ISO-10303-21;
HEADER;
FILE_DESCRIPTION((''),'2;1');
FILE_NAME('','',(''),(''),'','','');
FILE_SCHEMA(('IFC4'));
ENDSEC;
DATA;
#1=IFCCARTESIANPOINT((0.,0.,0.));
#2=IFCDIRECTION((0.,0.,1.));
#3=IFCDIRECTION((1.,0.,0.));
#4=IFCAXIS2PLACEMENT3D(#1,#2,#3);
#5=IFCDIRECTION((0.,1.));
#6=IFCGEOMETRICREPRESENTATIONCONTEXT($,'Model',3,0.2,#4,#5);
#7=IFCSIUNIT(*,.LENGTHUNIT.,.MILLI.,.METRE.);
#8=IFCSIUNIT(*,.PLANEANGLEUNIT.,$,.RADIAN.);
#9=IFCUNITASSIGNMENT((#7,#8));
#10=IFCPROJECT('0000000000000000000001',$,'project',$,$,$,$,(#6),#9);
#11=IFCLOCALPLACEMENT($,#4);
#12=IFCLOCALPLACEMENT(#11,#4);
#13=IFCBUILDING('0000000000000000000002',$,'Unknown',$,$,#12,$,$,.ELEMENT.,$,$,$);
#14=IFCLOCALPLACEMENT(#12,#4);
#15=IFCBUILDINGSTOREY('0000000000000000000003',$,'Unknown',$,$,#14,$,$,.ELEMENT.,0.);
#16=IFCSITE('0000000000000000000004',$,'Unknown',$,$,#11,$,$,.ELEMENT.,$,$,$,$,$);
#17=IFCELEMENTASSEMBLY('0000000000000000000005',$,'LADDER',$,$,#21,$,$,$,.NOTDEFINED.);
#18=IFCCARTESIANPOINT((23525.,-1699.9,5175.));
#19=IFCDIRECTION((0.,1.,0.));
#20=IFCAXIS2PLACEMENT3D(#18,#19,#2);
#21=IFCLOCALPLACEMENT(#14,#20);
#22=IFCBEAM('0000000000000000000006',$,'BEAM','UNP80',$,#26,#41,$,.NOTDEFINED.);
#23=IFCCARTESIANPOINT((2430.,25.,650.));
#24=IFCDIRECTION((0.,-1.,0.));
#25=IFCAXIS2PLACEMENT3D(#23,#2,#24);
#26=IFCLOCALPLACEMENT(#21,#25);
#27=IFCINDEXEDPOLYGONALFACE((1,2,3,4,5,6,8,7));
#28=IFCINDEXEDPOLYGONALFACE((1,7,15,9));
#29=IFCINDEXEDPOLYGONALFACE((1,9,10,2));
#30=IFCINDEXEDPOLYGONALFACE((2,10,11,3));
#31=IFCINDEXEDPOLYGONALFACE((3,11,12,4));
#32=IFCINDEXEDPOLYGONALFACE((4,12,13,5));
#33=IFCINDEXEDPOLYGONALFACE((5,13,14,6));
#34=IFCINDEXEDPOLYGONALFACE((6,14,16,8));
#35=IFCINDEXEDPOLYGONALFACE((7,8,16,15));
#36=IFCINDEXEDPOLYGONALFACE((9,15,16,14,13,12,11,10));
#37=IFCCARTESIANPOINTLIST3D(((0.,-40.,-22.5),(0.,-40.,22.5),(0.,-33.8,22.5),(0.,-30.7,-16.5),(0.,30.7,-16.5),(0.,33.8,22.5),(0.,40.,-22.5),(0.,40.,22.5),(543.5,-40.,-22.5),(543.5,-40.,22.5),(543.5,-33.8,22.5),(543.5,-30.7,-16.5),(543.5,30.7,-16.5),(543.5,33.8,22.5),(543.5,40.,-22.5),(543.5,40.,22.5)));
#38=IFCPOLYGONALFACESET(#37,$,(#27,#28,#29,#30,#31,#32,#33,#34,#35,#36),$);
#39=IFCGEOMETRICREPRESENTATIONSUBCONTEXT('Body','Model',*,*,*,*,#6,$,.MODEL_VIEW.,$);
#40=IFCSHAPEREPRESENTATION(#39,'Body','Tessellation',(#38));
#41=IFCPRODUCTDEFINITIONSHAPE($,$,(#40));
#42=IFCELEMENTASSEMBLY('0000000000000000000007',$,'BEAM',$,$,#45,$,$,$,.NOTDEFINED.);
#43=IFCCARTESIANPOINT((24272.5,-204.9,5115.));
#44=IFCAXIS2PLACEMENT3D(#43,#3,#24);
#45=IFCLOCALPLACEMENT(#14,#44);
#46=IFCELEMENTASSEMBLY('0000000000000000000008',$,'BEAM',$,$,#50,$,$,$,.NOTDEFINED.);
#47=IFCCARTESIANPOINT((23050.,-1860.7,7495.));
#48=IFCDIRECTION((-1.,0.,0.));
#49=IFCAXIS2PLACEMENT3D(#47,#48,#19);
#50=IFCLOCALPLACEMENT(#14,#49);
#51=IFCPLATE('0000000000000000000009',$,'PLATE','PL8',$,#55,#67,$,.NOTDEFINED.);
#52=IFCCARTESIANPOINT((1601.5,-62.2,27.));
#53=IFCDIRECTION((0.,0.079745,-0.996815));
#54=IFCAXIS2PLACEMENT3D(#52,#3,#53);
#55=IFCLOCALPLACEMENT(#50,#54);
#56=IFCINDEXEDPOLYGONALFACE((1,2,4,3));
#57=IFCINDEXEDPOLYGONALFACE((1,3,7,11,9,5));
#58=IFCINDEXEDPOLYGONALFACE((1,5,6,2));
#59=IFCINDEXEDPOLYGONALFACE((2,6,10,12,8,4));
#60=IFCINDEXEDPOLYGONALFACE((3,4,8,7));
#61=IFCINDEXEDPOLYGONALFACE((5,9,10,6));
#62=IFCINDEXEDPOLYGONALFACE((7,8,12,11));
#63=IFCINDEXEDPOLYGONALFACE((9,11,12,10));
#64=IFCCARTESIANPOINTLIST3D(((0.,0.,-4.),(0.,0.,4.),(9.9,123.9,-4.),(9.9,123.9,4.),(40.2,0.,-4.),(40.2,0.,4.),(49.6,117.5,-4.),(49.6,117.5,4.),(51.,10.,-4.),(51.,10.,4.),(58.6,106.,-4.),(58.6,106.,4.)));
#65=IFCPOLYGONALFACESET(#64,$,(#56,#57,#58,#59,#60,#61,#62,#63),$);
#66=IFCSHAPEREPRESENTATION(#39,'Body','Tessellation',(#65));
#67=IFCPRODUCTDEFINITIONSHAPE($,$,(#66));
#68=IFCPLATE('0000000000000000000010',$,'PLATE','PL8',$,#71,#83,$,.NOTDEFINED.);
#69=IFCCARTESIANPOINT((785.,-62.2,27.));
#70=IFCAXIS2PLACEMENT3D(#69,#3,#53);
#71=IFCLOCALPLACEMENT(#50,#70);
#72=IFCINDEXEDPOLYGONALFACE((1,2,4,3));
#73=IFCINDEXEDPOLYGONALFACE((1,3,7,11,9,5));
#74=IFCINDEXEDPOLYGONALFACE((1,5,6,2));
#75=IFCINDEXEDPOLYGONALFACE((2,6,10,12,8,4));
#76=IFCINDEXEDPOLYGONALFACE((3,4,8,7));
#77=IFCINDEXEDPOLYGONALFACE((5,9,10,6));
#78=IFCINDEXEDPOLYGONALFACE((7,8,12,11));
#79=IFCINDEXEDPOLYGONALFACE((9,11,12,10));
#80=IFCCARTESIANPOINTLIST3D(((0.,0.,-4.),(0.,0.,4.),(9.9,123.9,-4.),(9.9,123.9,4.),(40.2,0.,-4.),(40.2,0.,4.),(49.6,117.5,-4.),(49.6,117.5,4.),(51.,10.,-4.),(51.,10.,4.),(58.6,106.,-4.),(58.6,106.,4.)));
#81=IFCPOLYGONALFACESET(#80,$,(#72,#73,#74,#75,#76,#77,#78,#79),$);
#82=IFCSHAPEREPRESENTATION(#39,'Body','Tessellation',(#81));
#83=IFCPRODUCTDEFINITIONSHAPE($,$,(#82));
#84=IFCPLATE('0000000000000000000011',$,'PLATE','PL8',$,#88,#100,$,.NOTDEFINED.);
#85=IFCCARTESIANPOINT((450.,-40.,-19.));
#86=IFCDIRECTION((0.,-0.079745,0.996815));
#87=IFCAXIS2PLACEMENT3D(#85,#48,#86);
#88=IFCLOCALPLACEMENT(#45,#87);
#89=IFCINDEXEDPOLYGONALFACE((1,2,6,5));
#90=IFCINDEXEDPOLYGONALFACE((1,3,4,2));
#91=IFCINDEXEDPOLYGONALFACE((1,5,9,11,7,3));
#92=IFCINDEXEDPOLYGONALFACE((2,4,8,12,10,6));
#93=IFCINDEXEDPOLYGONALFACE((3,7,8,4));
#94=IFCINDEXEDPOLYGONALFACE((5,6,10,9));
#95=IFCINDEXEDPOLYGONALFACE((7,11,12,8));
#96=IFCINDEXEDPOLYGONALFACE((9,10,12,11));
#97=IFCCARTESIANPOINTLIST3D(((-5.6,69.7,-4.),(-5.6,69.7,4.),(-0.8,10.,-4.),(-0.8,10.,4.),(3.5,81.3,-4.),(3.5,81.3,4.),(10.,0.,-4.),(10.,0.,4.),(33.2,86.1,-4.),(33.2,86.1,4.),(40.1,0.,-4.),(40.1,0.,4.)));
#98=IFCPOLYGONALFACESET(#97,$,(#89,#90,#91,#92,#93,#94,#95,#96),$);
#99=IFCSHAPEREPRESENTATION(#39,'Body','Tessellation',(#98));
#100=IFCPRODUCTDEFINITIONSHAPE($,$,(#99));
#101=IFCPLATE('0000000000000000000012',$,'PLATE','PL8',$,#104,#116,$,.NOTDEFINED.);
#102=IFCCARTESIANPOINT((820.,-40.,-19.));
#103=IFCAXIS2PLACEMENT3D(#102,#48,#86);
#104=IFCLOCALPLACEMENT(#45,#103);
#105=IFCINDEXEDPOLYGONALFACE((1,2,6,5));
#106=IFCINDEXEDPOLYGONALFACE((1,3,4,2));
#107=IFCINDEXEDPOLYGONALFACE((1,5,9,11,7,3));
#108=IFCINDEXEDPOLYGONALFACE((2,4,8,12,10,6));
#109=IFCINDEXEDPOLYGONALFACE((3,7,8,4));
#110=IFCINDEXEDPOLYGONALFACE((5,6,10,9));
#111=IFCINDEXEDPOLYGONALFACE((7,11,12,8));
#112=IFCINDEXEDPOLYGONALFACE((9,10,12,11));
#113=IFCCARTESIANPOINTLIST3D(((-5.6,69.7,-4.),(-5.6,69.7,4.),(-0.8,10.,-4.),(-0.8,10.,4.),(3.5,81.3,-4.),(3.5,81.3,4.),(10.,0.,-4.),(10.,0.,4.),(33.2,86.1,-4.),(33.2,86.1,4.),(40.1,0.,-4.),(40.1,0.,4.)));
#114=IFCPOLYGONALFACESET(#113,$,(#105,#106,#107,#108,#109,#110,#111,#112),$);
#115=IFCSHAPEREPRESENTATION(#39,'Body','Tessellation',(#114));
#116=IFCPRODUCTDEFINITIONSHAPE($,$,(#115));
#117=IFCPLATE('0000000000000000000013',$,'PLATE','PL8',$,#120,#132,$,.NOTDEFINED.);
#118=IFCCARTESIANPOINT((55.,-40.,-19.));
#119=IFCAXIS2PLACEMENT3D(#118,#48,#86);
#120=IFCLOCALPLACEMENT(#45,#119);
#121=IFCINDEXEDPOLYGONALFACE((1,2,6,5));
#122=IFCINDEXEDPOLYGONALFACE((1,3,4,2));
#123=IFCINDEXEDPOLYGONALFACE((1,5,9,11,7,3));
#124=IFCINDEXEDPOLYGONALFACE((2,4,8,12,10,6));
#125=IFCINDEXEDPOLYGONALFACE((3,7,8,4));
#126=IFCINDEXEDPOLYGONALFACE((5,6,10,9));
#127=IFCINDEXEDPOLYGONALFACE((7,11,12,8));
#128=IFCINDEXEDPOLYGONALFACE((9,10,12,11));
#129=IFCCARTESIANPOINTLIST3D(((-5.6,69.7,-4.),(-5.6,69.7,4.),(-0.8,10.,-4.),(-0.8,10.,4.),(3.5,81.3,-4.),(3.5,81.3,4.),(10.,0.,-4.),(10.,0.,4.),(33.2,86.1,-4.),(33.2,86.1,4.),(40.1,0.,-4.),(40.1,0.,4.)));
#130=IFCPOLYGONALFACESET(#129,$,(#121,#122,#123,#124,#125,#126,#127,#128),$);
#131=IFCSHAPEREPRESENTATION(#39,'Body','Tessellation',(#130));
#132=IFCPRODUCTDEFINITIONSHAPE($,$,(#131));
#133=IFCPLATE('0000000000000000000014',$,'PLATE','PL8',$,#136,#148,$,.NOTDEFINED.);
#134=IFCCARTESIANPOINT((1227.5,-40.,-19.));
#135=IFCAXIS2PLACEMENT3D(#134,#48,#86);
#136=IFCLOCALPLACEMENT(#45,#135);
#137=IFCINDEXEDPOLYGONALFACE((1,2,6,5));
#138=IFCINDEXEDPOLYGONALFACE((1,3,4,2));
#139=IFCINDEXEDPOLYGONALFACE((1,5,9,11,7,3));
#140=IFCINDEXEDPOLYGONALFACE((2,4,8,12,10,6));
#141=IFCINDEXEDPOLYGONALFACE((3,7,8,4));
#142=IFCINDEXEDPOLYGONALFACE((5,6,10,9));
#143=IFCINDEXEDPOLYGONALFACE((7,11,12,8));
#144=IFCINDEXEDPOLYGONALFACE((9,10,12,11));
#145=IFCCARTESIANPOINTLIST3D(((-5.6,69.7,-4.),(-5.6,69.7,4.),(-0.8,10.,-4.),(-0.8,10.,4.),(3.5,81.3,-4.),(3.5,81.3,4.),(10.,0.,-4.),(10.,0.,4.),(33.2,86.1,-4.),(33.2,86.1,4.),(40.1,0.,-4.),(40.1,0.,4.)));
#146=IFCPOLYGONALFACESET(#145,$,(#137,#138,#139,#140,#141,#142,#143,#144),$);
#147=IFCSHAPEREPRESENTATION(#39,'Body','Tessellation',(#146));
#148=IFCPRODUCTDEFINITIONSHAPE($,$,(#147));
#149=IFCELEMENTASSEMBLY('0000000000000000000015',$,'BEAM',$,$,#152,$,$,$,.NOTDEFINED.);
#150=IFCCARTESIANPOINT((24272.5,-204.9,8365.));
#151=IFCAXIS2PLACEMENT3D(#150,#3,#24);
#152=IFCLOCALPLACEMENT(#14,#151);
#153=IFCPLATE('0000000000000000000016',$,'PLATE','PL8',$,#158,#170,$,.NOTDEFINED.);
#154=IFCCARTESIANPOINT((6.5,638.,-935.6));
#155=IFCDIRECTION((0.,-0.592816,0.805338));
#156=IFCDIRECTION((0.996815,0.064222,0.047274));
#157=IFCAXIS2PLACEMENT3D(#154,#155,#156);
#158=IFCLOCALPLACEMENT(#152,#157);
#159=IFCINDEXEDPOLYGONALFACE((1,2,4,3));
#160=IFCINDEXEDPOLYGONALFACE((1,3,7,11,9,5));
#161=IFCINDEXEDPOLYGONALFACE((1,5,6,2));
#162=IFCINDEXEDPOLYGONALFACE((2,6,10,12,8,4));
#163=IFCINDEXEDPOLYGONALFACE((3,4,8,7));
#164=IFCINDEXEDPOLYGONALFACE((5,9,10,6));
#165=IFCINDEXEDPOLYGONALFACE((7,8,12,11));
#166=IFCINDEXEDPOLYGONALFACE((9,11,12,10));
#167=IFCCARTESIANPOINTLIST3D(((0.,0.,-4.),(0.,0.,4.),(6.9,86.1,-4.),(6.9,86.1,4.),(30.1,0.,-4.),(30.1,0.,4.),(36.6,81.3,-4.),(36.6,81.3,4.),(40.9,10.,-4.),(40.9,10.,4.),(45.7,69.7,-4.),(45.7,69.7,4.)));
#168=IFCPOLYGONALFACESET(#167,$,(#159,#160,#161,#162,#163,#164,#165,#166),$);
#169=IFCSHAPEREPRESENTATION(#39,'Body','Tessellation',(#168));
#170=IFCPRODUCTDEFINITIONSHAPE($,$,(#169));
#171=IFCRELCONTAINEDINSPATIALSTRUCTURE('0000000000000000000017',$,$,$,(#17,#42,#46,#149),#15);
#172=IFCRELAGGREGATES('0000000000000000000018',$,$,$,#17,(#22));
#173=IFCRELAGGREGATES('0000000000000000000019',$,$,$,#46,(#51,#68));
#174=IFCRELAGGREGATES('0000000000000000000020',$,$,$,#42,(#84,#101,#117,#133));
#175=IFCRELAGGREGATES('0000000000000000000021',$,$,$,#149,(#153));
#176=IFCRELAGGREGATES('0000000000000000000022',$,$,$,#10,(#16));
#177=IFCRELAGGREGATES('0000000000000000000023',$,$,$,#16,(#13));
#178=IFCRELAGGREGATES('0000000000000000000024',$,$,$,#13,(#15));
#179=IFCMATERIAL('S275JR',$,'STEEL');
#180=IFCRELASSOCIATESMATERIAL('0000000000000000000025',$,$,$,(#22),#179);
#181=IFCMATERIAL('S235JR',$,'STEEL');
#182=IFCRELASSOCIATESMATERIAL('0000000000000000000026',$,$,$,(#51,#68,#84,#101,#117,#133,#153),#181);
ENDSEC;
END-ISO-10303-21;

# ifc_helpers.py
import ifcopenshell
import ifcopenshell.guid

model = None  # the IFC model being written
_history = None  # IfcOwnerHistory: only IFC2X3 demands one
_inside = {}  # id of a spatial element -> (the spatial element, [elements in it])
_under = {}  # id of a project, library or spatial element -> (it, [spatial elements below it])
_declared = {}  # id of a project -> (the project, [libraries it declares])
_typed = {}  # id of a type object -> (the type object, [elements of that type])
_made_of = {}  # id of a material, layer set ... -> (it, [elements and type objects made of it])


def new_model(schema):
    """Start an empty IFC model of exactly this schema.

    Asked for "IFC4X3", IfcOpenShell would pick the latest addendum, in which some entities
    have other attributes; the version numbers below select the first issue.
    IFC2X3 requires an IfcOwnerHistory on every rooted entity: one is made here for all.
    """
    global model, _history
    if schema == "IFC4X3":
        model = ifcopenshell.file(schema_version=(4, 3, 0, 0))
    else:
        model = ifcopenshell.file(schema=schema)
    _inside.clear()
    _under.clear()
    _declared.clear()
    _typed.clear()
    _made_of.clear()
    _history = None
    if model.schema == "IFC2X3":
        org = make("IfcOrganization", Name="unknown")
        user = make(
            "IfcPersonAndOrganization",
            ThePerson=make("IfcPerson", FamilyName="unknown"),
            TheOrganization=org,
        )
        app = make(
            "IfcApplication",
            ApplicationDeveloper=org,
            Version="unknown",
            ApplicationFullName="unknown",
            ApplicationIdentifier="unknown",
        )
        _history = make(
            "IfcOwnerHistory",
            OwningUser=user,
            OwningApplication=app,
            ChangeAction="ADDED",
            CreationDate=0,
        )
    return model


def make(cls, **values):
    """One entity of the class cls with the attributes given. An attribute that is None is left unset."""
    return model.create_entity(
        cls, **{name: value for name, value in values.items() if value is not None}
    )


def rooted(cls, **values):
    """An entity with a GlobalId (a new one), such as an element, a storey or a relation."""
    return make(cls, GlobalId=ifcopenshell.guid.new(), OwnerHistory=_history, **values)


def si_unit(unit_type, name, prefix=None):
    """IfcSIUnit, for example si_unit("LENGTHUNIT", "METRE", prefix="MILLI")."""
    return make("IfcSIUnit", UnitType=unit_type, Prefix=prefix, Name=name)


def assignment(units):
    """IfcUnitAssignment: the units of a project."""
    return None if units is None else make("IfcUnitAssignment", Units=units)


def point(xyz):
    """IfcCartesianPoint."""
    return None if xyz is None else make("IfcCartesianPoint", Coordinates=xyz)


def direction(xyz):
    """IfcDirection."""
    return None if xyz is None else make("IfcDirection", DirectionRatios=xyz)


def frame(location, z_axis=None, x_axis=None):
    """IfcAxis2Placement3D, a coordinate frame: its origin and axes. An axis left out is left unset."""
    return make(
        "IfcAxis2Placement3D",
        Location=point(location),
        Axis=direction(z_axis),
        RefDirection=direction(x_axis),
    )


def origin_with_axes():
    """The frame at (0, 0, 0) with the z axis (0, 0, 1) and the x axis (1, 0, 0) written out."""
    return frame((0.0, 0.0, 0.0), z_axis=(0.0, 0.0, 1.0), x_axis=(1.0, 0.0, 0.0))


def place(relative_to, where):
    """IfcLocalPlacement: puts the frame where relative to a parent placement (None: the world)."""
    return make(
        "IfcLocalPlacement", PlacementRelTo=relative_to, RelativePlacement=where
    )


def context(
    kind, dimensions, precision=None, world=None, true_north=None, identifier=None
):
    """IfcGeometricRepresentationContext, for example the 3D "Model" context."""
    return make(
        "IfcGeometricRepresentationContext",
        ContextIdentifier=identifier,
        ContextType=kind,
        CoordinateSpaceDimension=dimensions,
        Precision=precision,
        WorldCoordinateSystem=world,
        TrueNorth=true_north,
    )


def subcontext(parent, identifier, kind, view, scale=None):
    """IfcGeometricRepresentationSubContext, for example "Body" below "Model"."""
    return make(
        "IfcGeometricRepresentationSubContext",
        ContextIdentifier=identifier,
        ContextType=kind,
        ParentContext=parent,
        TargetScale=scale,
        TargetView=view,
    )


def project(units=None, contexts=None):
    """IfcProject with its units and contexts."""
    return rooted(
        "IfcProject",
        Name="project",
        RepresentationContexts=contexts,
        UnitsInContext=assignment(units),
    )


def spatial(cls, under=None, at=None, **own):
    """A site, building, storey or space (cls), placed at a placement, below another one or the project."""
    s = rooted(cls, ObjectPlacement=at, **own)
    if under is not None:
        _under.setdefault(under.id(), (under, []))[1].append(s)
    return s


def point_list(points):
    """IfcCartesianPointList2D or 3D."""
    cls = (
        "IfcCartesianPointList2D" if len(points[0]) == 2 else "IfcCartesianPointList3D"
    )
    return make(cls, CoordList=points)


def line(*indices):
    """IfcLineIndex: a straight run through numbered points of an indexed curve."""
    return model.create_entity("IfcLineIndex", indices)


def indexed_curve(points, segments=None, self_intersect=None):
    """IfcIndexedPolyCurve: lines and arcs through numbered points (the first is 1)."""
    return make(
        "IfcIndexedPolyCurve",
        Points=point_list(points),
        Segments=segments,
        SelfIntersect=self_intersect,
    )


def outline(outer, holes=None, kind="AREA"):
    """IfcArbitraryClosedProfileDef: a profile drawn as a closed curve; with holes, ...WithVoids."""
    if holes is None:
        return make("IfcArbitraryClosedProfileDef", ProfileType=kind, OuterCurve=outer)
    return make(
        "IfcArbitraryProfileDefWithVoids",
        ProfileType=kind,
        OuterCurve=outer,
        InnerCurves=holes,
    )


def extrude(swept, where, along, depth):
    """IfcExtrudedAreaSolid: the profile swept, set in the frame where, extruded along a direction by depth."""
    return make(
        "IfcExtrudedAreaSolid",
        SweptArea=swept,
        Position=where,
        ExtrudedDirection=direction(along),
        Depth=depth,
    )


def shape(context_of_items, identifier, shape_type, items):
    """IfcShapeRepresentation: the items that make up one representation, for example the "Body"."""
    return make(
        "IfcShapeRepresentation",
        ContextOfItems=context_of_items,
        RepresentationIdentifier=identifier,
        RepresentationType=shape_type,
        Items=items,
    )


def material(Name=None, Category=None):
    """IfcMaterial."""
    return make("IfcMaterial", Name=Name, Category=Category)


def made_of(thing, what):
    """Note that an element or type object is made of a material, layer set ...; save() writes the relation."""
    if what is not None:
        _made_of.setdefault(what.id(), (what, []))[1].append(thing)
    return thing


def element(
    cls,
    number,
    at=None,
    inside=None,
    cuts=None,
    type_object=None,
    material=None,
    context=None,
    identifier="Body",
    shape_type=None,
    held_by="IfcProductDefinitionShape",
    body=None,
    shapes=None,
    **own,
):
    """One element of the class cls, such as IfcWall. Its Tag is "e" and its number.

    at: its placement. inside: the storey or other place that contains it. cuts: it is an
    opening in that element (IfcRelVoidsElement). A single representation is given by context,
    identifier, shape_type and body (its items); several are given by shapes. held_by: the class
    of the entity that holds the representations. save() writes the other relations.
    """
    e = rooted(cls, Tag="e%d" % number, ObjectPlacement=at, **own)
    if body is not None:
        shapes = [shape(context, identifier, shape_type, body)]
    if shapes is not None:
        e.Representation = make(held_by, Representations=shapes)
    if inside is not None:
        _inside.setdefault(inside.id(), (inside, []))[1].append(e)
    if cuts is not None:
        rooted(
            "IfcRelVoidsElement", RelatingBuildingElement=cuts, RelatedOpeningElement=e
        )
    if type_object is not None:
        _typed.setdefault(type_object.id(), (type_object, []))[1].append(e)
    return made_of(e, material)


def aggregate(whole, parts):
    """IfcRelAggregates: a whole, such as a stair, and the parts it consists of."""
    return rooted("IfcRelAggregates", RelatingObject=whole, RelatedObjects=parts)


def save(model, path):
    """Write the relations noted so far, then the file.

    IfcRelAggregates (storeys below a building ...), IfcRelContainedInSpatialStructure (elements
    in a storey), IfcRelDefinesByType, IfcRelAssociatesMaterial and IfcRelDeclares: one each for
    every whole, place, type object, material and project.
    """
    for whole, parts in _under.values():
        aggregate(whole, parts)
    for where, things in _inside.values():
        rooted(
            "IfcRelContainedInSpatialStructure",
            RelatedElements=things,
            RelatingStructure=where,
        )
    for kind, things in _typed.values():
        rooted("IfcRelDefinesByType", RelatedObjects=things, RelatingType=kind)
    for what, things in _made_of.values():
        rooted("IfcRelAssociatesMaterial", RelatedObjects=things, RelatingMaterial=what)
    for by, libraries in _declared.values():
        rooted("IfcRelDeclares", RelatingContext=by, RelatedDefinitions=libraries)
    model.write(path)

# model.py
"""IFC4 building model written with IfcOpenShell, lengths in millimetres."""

from ifc_helpers import new_model, si_unit, direction, frame, origin_with_axes, place, context, subcontext, project, spatial, line, indexed_curve, outline, extrude, material, element, aggregate, save


model = new_model("IFC4")

# Units and contexts
model_context = context("Model", 3, precision=0.2, world=origin_with_axes(), true_north=direction((0.0, 1.0)))
body_context = subcontext(model_context, "Body", "Model", "MODEL_VIEW")
ifc_project = project(units=[si_unit("LENGTHUNIT", "METRE", prefix="MILLI"), si_unit("PLANEANGLEUNIT", "RADIAN")], contexts=[model_context])

# Site, building, storey
site_placement = place(None, origin_with_axes())
site = spatial("IfcSite", under=ifc_project, at=site_placement, Name="Unknown", CompositionType="ELEMENT")
building_placement = place(site_placement, origin_with_axes())
building = spatial("IfcBuilding", under=site, at=building_placement, Name="Unknown", CompositionType="ELEMENT")
storey_placement = place(building_placement, origin_with_axes())
storey = spatial("IfcBuildingStorey", under=building, at=storey_placement, Name="Unknown", CompositionType="ELEMENT", Elevation=0.0)

# Element assembly
assembly_1_placement = place(storey_placement, frame((23525.0, -1699.9, 5175.0), z_axis=(0.0, 1.0, 0.0), x_axis=(0.0, 0.0, 1.0)))
assembly_1 = element("IfcElementAssembly", 1, at=assembly_1_placement, inside=storey, Name="LADDER", PredefinedType="NOTDEFINED")
ifc_material_1 = material(Name="S235JR", Category="STEEL")

# Beam
ifc_material_2 = material(Name="S275JR", Category="STEEL")
beam_1_placement = place(assembly_1_placement, frame((2430.0, 25.0, 650.0), z_axis=(0.0, 0.0, 1.0), x_axis=(0.0, -1.0, 0.0)))
beam_1 = element("IfcBeam", 2, at=beam_1_placement, material=ifc_material_2, Name="BEAM", Description="UNP80", PredefinedType="NOTDEFINED", context=body_context, shape_type="SolidModel", body=[
    extrude(outline(indexed_curve([(-22.5, -40.0), (22.5, -40.0), (22.5, -33.8), (-16.5, -30.7), (-16.5, 30.7), (22.5, 33.8), (22.5, 40.0), (-22.5, 40.0)], segments=[line(1, 2, 3, 4, 5, 6, 7, 8, 1)])), frame((0.0, 0.0, 0.0), z_axis=(-1.0, 0.0, 0.0), x_axis=(0.0, 0.0, 1.0)), (0.0, 0.0, -1.0), 543.5),
])

# Element assembly
assembly_2_placement = place(storey_placement, frame((24272.5, -204.9, 5115.0), z_axis=(1.0, 0.0, 0.0), x_axis=(0.0, -1.0, 0.0)))
assembly_2 = element("IfcElementAssembly", 3, at=assembly_2_placement, inside=storey, Name="BEAM", PredefinedType="NOTDEFINED")

aggregate(assembly_1, [beam_1])

# Element assembly, plates
assembly_3_placement = place(storey_placement, frame((23050.0, -1860.7, 7495.0), z_axis=(-1.0, 0.0, 0.0), x_axis=(0.0, 1.0, 0.0)))
assembly_3 = element("IfcElementAssembly", 4, at=assembly_3_placement, inside=storey, Name="BEAM", PredefinedType="NOTDEFINED")
plate_1_placement = place(assembly_3_placement, frame((1601.5, -62.2, 27.0), z_axis=(1.0, 0.0, 0.0), x_axis=(0.0, 0.079745, -0.996815)))
plate_1 = element("IfcPlate", 5, at=plate_1_placement, material=ifc_material_1, Name="PLATE", Description="PL8", PredefinedType="NOTDEFINED", context=body_context, shape_type="SolidModel", body=[
    extrude(outline(indexed_curve([(0.0, 0.0), (40.2, 0.0), (51.0, 10.0), (58.6, 106.0), (49.6, 117.5), (9.9, 123.9)], segments=[line(1, 2, 3, 4, 5, 6, 1)])), frame((0.0, 0.0, 4.0), z_axis=(0.0, 0.0, 1.0), x_axis=(1.0, 0.0, 0.0)), (0.0, 0.0, -1.0), 8.0),
])
plate_2_placement = place(assembly_3_placement, frame((785.0, -62.2, 27.0), z_axis=(1.0, 0.0, 0.0), x_axis=(0.0, 0.079745, -0.996815)))
plate_2 = element("IfcPlate", 6, at=plate_2_placement, material=ifc_material_1, Name="PLATE", Description="PL8", PredefinedType="NOTDEFINED", context=body_context, shape_type="SolidModel", body=[
    extrude(outline(indexed_curve([(0.0, 0.0), (40.2, 0.0), (51.0, 10.0), (58.6, 106.0), (49.6, 117.5), (9.9, 123.9)], segments=[line(1, 2, 3, 4, 5, 6, 1)])), frame((0.0, 0.0, 4.0), z_axis=(0.0, 0.0, 1.0), x_axis=(1.0, 0.0, 0.0)), (0.0, 0.0, -1.0), 8.0),
])
aggregate(assembly_3, [plate_1, plate_2])

# Plates
plate_3_placement = place(assembly_2_placement, frame((450.0, -40.0, -19.0), z_axis=(-1.0, 0.0, 0.0), x_axis=(0.0, -0.079745, 0.996815)))
plate_3 = element("IfcPlate", 7, at=plate_3_placement, material=ifc_material_1, Name="PLATE", Description="PL8", PredefinedType="NOTDEFINED", context=body_context, shape_type="SolidModel", body=[
    extrude(outline(indexed_curve([(-0.8, 10.0), (10.0, 0.0), (40.1, 0.0), (33.2, 86.1), (3.5, 81.3), (-5.6, 69.7)], segments=[line(1, 2, 3, 4, 5, 6, 1)])), frame((0.0, 0.0, 4.0), z_axis=(0.0, 0.0, 1.0), x_axis=(1.0, 0.0, 0.0)), (0.0, 0.0, -1.0), 8.0),
])
plate_4_placement = place(assembly_2_placement, frame((820.0, -40.0, -19.0), z_axis=(-1.0, 0.0, 0.0), x_axis=(0.0, -0.079745, 0.996815)))
plate_4 = element("IfcPlate", 8, at=plate_4_placement, material=ifc_material_1, Name="PLATE", Description="PL8", PredefinedType="NOTDEFINED", context=body_context, shape_type="SolidModel", body=[
    extrude(outline(indexed_curve([(-0.8, 10.0), (10.0, 0.0), (40.1, 0.0), (33.2, 86.1), (3.5, 81.3), (-5.6, 69.7)], segments=[line(1, 2, 3, 4, 5, 6, 1)])), frame((0.0, 0.0, 4.0), z_axis=(0.0, 0.0, 1.0), x_axis=(1.0, 0.0, 0.0)), (0.0, 0.0, -1.0), 8.0),
])
plate_5_placement = place(assembly_2_placement, frame((55.0, -40.0, -19.0), z_axis=(-1.0, 0.0, 0.0), x_axis=(0.0, -0.079745, 0.996815)))
plate_5 = element("IfcPlate", 9, at=plate_5_placement, material=ifc_material_1, Name="PLATE", Description="PL8", PredefinedType="NOTDEFINED", context=body_context, shape_type="SolidModel", body=[
    extrude(outline(indexed_curve([(-0.8, 10.0), (10.0, 0.0), (40.1, 0.0), (33.2, 86.1), (3.5, 81.3), (-5.6, 69.7)], segments=[line(1, 2, 3, 4, 5, 6, 1)])), frame((0.0, 0.0, 4.0), z_axis=(0.0, 0.0, 1.0), x_axis=(1.0, 0.0, 0.0)), (0.0, 0.0, -1.0), 8.0),
])
plate_6_placement = place(assembly_2_placement, frame((1227.5, -40.0, -19.0), z_axis=(-1.0, 0.0, 0.0), x_axis=(0.0, -0.079745, 0.996815)))
plate_6 = element("IfcPlate", 10, at=plate_6_placement, material=ifc_material_1, Name="PLATE", Description="PL8", PredefinedType="NOTDEFINED", context=body_context, shape_type="SolidModel", body=[
    extrude(outline(indexed_curve([(-0.8, 10.0), (10.0, 0.0), (40.1, 0.0), (33.2, 86.1), (3.5, 81.3), (-5.6, 69.7)], segments=[line(1, 2, 3, 4, 5, 6, 1)])), frame((0.0, 0.0, 4.0), z_axis=(0.0, 0.0, 1.0), x_axis=(1.0, 0.0, 0.0)), (0.0, 0.0, -1.0), 8.0),
])
aggregate(assembly_2, [plate_3, plate_4, plate_5, plate_6])

# Element assembly, plate
assembly_4_placement = place(storey_placement, frame((24272.5, -204.9, 8365.0), z_axis=(1.0, 0.0, 0.0), x_axis=(0.0, -1.0, 0.0)))
assembly_4 = element("IfcElementAssembly", 11, at=assembly_4_placement, inside=storey, Name="BEAM", PredefinedType="NOTDEFINED")
plate_7_placement = place(assembly_4_placement, frame((6.5, 638.0, -935.6), z_axis=(0.0, -0.592816, 0.805338), x_axis=(0.996815, 0.064222, 0.047274)))
plate_7 = element("IfcPlate", 12, at=plate_7_placement, material=ifc_material_1, Name="PLATE", Description="PL8", PredefinedType="NOTDEFINED", context=body_context, shape_type="SolidModel", body=[
    extrude(outline(indexed_curve([(0.0, 0.0), (30.1, 0.0), (40.9, 10.0), (45.7, 69.7), (36.6, 81.3), (6.9, 86.1)], segments=[line(1, 2, 3, 4, 5, 6, 1)])), frame((0.0, 0.0, 4.0), z_axis=(0.0, 0.0, 1.0), x_axis=(1.0, 0.0, 0.0)), (0.0, 0.0, -1.0), 8.0),
])
aggregate(assembly_4, [plate_7])

save(model, "model.ifc")
